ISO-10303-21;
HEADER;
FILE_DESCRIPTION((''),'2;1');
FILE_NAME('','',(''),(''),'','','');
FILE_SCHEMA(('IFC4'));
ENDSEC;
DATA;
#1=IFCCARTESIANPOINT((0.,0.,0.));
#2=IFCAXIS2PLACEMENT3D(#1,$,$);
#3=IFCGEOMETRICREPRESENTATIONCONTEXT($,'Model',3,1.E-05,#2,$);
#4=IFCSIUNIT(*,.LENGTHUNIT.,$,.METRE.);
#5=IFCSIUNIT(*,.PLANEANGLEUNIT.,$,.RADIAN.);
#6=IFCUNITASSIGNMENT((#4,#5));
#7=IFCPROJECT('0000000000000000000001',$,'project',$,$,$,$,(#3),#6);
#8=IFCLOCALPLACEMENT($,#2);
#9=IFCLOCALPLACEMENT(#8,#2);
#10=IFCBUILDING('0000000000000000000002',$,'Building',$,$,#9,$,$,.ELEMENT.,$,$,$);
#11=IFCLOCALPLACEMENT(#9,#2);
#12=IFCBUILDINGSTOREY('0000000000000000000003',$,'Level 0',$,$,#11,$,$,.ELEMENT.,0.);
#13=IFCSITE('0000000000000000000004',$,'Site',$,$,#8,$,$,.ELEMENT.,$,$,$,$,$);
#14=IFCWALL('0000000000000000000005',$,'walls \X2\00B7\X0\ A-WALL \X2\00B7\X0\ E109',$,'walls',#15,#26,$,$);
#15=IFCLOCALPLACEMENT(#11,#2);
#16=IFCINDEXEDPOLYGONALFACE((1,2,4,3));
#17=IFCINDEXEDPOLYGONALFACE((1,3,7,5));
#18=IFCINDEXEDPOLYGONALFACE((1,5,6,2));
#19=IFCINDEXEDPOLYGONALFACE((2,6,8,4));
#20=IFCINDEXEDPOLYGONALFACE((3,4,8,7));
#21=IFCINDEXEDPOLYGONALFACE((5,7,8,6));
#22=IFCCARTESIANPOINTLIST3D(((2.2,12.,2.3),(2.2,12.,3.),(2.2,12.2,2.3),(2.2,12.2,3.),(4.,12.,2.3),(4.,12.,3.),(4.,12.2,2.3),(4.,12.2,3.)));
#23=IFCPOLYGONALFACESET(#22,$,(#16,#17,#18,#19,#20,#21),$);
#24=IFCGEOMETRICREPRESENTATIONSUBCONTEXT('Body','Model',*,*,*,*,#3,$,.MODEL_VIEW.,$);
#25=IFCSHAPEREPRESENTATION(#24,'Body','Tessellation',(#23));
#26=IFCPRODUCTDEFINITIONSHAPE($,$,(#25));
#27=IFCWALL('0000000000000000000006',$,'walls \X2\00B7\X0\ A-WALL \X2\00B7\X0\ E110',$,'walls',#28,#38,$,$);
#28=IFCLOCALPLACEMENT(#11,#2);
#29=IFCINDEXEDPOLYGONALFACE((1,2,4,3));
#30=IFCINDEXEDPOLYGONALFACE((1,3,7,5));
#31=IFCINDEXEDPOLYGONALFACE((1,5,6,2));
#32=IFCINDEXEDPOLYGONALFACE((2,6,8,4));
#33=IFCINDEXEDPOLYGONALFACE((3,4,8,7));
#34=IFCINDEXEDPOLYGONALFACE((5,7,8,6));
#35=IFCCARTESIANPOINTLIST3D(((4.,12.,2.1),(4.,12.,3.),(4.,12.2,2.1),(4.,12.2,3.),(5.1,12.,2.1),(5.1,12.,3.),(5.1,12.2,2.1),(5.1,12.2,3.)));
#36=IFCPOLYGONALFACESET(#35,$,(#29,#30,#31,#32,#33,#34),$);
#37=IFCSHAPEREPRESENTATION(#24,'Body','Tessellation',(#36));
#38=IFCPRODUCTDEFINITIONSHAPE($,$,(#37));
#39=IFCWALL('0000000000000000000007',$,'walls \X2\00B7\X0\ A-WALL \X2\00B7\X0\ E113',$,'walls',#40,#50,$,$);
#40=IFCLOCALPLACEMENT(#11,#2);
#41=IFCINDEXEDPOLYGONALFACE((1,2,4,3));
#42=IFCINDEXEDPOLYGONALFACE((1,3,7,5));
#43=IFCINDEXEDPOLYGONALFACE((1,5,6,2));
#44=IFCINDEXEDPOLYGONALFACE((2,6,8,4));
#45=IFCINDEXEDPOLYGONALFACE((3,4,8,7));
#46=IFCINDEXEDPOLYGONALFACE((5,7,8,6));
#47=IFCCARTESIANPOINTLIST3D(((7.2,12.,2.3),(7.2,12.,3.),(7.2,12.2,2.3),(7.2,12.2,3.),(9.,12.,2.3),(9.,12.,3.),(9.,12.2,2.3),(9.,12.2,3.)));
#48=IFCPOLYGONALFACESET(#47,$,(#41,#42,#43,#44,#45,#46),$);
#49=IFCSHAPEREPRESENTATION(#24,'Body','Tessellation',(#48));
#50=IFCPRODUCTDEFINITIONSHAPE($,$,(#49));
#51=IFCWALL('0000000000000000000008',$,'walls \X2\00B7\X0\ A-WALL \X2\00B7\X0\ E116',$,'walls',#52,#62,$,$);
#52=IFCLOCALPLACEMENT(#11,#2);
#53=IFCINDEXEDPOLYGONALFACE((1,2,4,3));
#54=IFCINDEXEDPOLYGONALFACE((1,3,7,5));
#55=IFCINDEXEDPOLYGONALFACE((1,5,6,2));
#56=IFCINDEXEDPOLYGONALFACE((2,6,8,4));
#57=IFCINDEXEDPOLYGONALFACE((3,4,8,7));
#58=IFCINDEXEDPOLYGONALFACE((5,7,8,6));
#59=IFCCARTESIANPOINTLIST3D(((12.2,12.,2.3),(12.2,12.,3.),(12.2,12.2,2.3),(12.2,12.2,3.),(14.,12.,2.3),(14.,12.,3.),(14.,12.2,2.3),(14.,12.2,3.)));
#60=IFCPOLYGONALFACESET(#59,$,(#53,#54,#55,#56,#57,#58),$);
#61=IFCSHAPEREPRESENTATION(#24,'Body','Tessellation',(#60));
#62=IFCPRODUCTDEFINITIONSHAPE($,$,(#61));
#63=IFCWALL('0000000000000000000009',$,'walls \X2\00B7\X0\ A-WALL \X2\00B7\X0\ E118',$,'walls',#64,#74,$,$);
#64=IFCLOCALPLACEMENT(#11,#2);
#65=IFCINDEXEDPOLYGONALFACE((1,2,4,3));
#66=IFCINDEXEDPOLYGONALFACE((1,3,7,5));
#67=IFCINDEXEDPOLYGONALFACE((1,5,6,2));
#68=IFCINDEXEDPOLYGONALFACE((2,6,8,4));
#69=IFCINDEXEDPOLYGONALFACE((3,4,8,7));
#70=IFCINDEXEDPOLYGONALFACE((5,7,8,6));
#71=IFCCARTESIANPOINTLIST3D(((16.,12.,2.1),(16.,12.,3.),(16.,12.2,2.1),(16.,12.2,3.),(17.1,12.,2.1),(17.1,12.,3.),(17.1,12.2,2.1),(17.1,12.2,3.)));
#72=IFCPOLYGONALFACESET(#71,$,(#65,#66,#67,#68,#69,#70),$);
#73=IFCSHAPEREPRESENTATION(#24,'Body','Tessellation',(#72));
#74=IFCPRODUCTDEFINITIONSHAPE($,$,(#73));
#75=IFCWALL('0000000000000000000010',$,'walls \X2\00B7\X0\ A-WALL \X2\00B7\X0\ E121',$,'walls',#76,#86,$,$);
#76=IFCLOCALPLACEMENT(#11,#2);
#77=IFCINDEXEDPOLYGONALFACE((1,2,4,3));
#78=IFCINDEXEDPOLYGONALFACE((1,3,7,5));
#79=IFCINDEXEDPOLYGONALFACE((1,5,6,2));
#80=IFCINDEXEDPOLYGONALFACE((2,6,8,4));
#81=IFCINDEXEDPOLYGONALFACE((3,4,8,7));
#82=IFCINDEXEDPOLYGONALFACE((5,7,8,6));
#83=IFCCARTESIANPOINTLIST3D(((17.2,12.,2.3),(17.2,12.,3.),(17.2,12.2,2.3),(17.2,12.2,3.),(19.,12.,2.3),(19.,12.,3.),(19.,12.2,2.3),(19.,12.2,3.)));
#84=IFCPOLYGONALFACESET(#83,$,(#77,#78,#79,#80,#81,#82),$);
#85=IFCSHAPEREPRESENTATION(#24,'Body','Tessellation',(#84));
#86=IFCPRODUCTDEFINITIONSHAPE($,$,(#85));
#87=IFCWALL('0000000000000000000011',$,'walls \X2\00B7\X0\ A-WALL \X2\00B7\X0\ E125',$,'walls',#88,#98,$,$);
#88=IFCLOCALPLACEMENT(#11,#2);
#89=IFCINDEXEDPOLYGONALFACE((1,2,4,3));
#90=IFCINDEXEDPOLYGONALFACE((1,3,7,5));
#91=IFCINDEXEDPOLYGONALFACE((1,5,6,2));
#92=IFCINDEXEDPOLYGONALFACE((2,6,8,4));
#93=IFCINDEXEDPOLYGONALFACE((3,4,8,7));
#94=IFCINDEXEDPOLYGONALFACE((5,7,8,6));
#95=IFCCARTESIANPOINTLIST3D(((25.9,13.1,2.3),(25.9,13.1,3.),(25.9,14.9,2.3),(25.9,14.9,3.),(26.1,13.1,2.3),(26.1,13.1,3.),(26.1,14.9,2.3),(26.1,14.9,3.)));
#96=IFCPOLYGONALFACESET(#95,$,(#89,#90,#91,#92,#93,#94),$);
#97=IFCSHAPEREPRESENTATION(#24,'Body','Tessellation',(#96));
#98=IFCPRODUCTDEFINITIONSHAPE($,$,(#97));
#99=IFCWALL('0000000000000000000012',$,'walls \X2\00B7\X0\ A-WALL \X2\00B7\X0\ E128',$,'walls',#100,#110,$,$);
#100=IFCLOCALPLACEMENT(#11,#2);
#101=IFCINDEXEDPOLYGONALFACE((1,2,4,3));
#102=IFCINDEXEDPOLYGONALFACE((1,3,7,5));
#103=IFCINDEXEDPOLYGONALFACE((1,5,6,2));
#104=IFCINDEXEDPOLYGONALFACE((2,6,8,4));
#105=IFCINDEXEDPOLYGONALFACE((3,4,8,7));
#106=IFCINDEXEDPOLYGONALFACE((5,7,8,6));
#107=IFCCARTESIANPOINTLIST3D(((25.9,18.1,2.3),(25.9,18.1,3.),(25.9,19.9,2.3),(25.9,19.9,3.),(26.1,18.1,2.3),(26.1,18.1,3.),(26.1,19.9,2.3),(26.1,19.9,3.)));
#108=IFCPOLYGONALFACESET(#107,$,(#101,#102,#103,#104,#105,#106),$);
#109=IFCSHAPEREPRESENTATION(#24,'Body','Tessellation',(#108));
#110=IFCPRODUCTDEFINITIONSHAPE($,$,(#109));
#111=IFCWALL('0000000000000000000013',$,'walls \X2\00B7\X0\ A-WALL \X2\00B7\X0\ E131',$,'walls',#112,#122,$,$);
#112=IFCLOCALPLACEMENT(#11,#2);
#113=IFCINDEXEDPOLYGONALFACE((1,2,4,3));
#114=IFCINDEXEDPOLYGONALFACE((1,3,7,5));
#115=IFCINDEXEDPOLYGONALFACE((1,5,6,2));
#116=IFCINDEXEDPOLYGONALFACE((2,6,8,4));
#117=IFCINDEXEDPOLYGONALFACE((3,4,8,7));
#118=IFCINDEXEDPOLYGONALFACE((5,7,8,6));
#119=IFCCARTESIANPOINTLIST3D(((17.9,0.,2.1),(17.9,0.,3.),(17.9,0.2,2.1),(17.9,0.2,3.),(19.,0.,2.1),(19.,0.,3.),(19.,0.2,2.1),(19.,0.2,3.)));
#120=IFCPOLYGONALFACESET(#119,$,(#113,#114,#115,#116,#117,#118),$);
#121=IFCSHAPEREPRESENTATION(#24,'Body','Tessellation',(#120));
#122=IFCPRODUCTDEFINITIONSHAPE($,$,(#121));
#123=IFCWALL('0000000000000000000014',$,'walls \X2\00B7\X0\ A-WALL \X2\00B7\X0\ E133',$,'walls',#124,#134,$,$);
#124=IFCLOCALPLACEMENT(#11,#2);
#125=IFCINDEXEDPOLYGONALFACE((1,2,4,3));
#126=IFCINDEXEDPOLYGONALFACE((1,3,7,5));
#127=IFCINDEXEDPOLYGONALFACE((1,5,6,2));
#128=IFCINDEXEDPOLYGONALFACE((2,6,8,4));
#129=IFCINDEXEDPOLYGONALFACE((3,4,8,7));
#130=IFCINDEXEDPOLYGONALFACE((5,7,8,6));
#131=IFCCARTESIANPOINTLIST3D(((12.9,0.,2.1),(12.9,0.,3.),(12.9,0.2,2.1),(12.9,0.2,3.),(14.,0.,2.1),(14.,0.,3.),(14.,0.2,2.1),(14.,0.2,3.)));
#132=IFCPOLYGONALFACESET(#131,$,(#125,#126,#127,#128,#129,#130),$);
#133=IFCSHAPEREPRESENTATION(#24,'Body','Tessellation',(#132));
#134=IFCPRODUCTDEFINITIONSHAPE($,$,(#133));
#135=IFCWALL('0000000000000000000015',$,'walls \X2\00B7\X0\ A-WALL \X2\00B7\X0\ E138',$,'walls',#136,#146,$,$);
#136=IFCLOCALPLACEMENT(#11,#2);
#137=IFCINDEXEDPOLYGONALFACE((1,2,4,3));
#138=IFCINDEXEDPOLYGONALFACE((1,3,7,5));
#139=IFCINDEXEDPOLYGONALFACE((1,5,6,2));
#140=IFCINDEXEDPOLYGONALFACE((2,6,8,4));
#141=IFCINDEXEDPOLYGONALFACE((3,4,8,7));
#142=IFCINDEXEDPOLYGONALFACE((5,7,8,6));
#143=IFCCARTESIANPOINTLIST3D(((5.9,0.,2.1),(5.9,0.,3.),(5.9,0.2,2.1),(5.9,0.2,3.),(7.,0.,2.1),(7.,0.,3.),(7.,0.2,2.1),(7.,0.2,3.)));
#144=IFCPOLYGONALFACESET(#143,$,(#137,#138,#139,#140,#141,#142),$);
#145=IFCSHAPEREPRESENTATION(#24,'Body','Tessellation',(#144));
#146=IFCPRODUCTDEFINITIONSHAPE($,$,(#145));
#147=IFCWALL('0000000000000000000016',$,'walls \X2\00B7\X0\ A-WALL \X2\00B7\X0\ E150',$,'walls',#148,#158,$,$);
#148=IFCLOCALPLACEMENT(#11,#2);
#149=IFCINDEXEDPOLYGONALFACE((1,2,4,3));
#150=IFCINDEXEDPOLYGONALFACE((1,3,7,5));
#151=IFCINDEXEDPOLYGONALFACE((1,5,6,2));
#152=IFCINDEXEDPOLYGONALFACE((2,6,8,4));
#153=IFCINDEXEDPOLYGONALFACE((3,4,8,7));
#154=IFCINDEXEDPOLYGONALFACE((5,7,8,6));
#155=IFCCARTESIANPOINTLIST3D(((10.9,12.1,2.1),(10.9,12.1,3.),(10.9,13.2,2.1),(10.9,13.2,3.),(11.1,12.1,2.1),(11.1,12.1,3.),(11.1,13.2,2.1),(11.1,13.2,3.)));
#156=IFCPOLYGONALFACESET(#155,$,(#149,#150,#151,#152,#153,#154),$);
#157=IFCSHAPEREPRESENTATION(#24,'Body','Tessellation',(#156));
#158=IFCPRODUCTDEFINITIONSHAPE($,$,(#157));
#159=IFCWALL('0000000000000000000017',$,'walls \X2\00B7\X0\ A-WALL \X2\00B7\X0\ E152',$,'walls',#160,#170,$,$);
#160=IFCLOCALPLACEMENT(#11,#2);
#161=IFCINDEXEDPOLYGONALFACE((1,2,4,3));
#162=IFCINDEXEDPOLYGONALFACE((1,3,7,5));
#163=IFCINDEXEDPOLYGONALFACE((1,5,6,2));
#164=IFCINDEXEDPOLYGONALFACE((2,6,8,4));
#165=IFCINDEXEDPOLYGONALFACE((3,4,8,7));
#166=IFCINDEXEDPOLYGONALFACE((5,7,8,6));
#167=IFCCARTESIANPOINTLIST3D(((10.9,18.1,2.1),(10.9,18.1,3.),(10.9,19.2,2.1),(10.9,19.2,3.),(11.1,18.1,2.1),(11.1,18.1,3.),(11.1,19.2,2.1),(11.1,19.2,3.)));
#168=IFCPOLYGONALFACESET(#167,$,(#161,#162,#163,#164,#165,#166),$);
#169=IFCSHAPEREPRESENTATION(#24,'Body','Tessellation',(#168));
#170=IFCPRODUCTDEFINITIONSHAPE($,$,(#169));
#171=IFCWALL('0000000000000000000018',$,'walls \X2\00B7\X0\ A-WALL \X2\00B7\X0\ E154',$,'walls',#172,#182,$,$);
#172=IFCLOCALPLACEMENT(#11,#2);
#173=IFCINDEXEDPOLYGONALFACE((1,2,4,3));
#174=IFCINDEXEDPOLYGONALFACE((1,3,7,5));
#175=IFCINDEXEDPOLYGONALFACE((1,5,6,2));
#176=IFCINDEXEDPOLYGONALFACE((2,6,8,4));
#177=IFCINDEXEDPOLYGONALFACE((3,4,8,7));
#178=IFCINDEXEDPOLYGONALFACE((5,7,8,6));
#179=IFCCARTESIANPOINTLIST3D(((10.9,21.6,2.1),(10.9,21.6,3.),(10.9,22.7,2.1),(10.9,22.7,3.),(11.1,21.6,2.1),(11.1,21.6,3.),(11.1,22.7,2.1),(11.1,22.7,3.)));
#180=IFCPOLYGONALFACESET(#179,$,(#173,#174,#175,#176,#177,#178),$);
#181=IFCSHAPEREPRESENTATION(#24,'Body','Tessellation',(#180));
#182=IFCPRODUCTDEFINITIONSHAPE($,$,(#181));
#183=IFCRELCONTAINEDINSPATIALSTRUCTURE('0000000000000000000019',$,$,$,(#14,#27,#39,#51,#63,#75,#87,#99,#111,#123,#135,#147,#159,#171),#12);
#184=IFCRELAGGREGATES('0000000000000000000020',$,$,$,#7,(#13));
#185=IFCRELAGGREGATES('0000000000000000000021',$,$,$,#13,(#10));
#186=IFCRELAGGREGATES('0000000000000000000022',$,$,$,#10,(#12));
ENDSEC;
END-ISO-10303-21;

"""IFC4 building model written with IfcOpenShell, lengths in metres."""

from ifc_helpers import new_model, si_unit, frame, origin, place, context, subcontext, project, spatial, polyline, outline, extrude, element, save


model = new_model("IFC4")

# Units and contexts
model_context = context("Model", 3, precision=1e-05, world=origin())
body_context = subcontext(model_context, "Body", "Model", "MODEL_VIEW")
ifc_project = project(units=[si_unit("LENGTHUNIT", "METRE"), si_unit("PLANEANGLEUNIT", "RADIAN")], contexts=[model_context])

# Site, building, storey
site_placement = place(None, origin())
site = spatial("IfcSite", under=ifc_project, at=site_placement, Name="Site", CompositionType="ELEMENT")
building_placement = place(site_placement, origin())
building = spatial("IfcBuilding", under=site, at=building_placement, Name="Building", CompositionType="ELEMENT")
storey_placement = place(building_placement, origin())
storey = spatial("IfcBuildingStorey", under=building, at=storey_placement, Name="Level 0", CompositionType="ELEMENT", Elevation=0.0)

# Wall
wall_1_placement = place(storey_placement, frame((0.0, 0.0, 2.3)))
element("IfcWall", 1, at=wall_1_placement, inside=storey, Name="walls · A-WALL · E109", ObjectType="walls", context=body_context, shape_type="SweptSolid", body=[
    extrude(outline(polyline([(2.2, 12.0), (4.0, 12.0), (4.0, 12.2), (2.2, 12.2), (2.2, 12.0)])), origin(), (0.0, 0.0, 1.0), 0.7),
])

# Wall, opening
wall_2_placement = place(storey_placement, frame((0.0, 0.0, 2.1)))
wall_2 = element("IfcWall", 2, at=wall_2_placement, inside=storey, Name="walls · A-WALL · E110", ObjectType="walls", context=body_context, shape_type="SweptSolid", body=[
    extrude(outline(polyline([(4.0, 12.0), (5.1, 12.0), (5.1, 12.2), (4.0, 12.2), (4.0, 12.0)])), origin(), (0.0, 0.0, 1.0), 0.9),
])
opening_1_placement = place(storey_placement, origin())
element("IfcOpeningElement", 3, at=opening_1_placement, cuts=wall_2, ObjectType="Opening", context=body_context, shape_type="SweptSolid", body=[
    extrude(outline(polyline([(4.0, 12.0), (5.1, 12.0), (5.1, 12.2), (4.0, 12.2), (4.0, 12.0)])), origin(), (0.0, 0.0, 1.0), 2.1),
])

# Walls
wall_3_placement = place(storey_placement, frame((0.0, 0.0, 2.3)))
element("IfcWall", 4, at=wall_3_placement, inside=storey, Name="walls · A-WALL · E113", ObjectType="walls", context=body_context, shape_type="SweptSolid", body=[
    extrude(outline(polyline([(7.2, 12.0), (9.0, 12.0), (9.0, 12.2), (7.2, 12.2), (7.2, 12.0)])), origin(), (0.0, 0.0, 1.0), 0.7),
])
wall_4_placement = place(storey_placement, frame((0.0, 0.0, 2.3)))
element("IfcWall", 5, at=wall_4_placement, inside=storey, Name="walls · A-WALL · E116", ObjectType="walls", context=body_context, shape_type="SweptSolid", body=[
    extrude(outline(polyline([(12.2, 12.0), (14.0, 12.0), (14.0, 12.2), (12.2, 12.2), (12.2, 12.0)])), origin(), (0.0, 0.0, 1.0), 0.7),
])

# Wall, opening
wall_5_placement = place(storey_placement, frame((0.0, 0.0, 2.1)))
wall_5 = element("IfcWall", 6, at=wall_5_placement, inside=storey, Name="walls · A-WALL · E118", ObjectType="walls", context=body_context, shape_type="SweptSolid", body=[
    extrude(outline(polyline([(16.0, 12.0), (17.1, 12.0), (17.1, 12.2), (16.0, 12.2), (16.0, 12.0)])), origin(), (0.0, 0.0, 1.0), 0.9),
])
opening_2_placement = place(storey_placement, origin())
element("IfcOpeningElement", 7, at=opening_2_placement, cuts=wall_5, ObjectType="Opening", context=body_context, shape_type="SweptSolid", body=[
    extrude(outline(polyline([(16.0, 12.0), (17.1, 12.0), (17.1, 12.2), (16.0, 12.2), (16.0, 12.0)])), origin(), (0.0, 0.0, 1.0), 2.1),
])

# Walls
wall_6_placement = place(storey_placement, frame((0.0, 0.0, 2.3)))
element("IfcWall", 8, at=wall_6_placement, inside=storey, Name="walls · A-WALL · E121", ObjectType="walls", context=body_context, shape_type="SweptSolid", body=[
    extrude(outline(polyline([(17.2, 12.0), (19.0, 12.0), (19.0, 12.2), (17.2, 12.2), (17.2, 12.0)])), origin(), (0.0, 0.0, 1.0), 0.7),
])
wall_7_placement = place(storey_placement, frame((0.0, 0.0, 2.3)))
element("IfcWall", 9, at=wall_7_placement, inside=storey, Name="walls · A-WALL · E125", ObjectType="walls", context=body_context, shape_type="SweptSolid", body=[
    extrude(outline(polyline([(26.1, 13.1), (26.1, 14.9), (25.9, 14.9), (25.9, 13.1), (26.1, 13.1)])), origin(), (0.0, 0.0, 1.0), 0.7),
])
wall_8_placement = place(storey_placement, frame((0.0, 0.0, 2.3)))
element("IfcWall", 10, at=wall_8_placement, inside=storey, Name="walls · A-WALL · E128", ObjectType="walls", context=body_context, shape_type="SweptSolid", body=[
    extrude(outline(polyline([(26.1, 18.1), (26.1, 19.9), (25.9, 19.9), (25.9, 18.1), (26.1, 18.1)])), origin(), (0.0, 0.0, 1.0), 0.7),
])

# Walls, openings
wall_9_placement = place(storey_placement, frame((0.0, 0.0, 2.1)))
wall_9 = element("IfcWall", 11, at=wall_9_placement, inside=storey, Name="walls · A-WALL · E131", ObjectType="walls", context=body_context, shape_type="SweptSolid", body=[
    extrude(outline(polyline([(19.0, 0.2), (17.9, 0.2), (17.9, 0.0), (19.0, 0.0), (19.0, 0.2)])), origin(), (0.0, 0.0, 1.0), 0.9),
])
opening_3_placement = place(storey_placement, origin())
element("IfcOpeningElement", 12, at=opening_3_placement, cuts=wall_9, ObjectType="Opening", context=body_context, shape_type="SweptSolid", body=[
    extrude(outline(polyline([(19.0, 0.2), (17.9, 0.2), (17.9, 0.0), (19.0, 0.0), (19.0, 0.2)])), origin(), (0.0, 0.0, 1.0), 2.1),
])
wall_10_placement = place(storey_placement, frame((0.0, 0.0, 2.1)))
wall_10 = element("IfcWall", 13, at=wall_10_placement, inside=storey, Name="walls · A-WALL · E133", ObjectType="walls", context=body_context, shape_type="SweptSolid", body=[
    extrude(outline(polyline([(14.0, 0.2), (12.9, 0.2), (12.9, 0.0), (14.0, 0.0), (14.0, 0.2)])), origin(), (0.0, 0.0, 1.0), 0.9),
])
opening_4_placement = place(storey_placement, origin())
element("IfcOpeningElement", 14, at=opening_4_placement, cuts=wall_10, ObjectType="Opening", context=body_context, shape_type="SweptSolid", body=[
    extrude(outline(polyline([(14.0, 0.2), (12.9, 0.2), (12.9, 0.0), (14.0, 0.0), (14.0, 0.2)])), origin(), (0.0, 0.0, 1.0), 2.1),
])
wall_11_placement = place(storey_placement, frame((0.0, 0.0, 2.1)))
wall_11 = element("IfcWall", 15, at=wall_11_placement, inside=storey, Name="walls · A-WALL · E138", ObjectType="walls", context=body_context, shape_type="SweptSolid", body=[
    extrude(outline(polyline([(7.0, 0.2), (5.9, 0.2), (5.9, 0.0), (7.0, 0.0), (7.0, 0.2)])), origin(), (0.0, 0.0, 1.0), 0.9),
])
opening_5_placement = place(storey_placement, origin())
element("IfcOpeningElement", 16, at=opening_5_placement, cuts=wall_11, ObjectType="Opening", context=body_context, shape_type="SweptSolid", body=[
    extrude(outline(polyline([(7.0, 0.2), (5.9, 0.2), (5.9, 0.0), (7.0, 0.0), (7.0, 0.2)])), origin(), (0.0, 0.0, 1.0), 2.1),
])
wall_12_placement = place(storey_placement, frame((0.0, 0.0, 2.1)))
wall_12 = element("IfcWall", 17, at=wall_12_placement, inside=storey, Name="walls · A-WALL · E150", ObjectType="walls", context=body_context, shape_type="SweptSolid", body=[
    extrude(outline(polyline([(11.1, 12.1), (11.1, 13.2), (10.9, 13.2), (10.9, 12.1), (11.1, 12.1)])), origin(), (0.0, 0.0, 1.0), 0.9),
])
opening_6_placement = place(storey_placement, origin())
element("IfcOpeningElement", 18, at=opening_6_placement, cuts=wall_12, ObjectType="Opening", context=body_context, shape_type="SweptSolid", body=[
    extrude(outline(polyline([(11.1, 12.1), (11.1, 13.2), (10.9, 13.2), (10.9, 12.1), (11.1, 12.1)])), origin(), (0.0, 0.0, 1.0), 2.1),
])
wall_13_placement = place(storey_placement, frame((0.0, 0.0, 2.1)))
wall_13 = element("IfcWall", 19, at=wall_13_placement, inside=storey, Name="walls · A-WALL · E152", ObjectType="walls", context=body_context, shape_type="SweptSolid", body=[
    extrude(outline(polyline([(11.1, 18.1), (11.1, 19.2), (10.9, 19.2), (10.9, 18.1), (11.1, 18.1)])), origin(), (0.0, 0.0, 1.0), 0.9),
])
opening_7_placement = place(storey_placement, origin())
element("IfcOpeningElement", 20, at=opening_7_placement, cuts=wall_13, ObjectType="Opening", context=body_context, shape_type="SweptSolid", body=[
    extrude(outline(polyline([(11.1, 18.1), (11.1, 19.2), (10.9, 19.2), (10.9, 18.1), (11.1, 18.1)])), origin(), (0.0, 0.0, 1.0), 2.1),
])
wall_14_placement = place(storey_placement, frame((0.0, 0.0, 2.1)))
wall_14 = element("IfcWall", 21, at=wall_14_placement, inside=storey, Name="walls · A-WALL · E154", ObjectType="walls", context=body_context, shape_type="SweptSolid", body=[
    extrude(outline(polyline([(11.1, 21.6), (11.1, 22.7), (10.9, 22.7), (10.9, 21.6), (11.1, 21.6)])), origin(), (0.0, 0.0, 1.0), 0.9),
])
opening_8_placement = place(storey_placement, origin())
element("IfcOpeningElement", 22, at=opening_8_placement, cuts=wall_14, ObjectType="Opening", context=body_context, shape_type="SweptSolid", body=[
    extrude(outline(polyline([(11.1, 21.6), (11.1, 22.7), (10.9, 22.7), (10.9, 21.6), (11.1, 21.6)])), origin(), (0.0, 0.0, 1.0), 2.1),
])

save(model, "model.ifc")
